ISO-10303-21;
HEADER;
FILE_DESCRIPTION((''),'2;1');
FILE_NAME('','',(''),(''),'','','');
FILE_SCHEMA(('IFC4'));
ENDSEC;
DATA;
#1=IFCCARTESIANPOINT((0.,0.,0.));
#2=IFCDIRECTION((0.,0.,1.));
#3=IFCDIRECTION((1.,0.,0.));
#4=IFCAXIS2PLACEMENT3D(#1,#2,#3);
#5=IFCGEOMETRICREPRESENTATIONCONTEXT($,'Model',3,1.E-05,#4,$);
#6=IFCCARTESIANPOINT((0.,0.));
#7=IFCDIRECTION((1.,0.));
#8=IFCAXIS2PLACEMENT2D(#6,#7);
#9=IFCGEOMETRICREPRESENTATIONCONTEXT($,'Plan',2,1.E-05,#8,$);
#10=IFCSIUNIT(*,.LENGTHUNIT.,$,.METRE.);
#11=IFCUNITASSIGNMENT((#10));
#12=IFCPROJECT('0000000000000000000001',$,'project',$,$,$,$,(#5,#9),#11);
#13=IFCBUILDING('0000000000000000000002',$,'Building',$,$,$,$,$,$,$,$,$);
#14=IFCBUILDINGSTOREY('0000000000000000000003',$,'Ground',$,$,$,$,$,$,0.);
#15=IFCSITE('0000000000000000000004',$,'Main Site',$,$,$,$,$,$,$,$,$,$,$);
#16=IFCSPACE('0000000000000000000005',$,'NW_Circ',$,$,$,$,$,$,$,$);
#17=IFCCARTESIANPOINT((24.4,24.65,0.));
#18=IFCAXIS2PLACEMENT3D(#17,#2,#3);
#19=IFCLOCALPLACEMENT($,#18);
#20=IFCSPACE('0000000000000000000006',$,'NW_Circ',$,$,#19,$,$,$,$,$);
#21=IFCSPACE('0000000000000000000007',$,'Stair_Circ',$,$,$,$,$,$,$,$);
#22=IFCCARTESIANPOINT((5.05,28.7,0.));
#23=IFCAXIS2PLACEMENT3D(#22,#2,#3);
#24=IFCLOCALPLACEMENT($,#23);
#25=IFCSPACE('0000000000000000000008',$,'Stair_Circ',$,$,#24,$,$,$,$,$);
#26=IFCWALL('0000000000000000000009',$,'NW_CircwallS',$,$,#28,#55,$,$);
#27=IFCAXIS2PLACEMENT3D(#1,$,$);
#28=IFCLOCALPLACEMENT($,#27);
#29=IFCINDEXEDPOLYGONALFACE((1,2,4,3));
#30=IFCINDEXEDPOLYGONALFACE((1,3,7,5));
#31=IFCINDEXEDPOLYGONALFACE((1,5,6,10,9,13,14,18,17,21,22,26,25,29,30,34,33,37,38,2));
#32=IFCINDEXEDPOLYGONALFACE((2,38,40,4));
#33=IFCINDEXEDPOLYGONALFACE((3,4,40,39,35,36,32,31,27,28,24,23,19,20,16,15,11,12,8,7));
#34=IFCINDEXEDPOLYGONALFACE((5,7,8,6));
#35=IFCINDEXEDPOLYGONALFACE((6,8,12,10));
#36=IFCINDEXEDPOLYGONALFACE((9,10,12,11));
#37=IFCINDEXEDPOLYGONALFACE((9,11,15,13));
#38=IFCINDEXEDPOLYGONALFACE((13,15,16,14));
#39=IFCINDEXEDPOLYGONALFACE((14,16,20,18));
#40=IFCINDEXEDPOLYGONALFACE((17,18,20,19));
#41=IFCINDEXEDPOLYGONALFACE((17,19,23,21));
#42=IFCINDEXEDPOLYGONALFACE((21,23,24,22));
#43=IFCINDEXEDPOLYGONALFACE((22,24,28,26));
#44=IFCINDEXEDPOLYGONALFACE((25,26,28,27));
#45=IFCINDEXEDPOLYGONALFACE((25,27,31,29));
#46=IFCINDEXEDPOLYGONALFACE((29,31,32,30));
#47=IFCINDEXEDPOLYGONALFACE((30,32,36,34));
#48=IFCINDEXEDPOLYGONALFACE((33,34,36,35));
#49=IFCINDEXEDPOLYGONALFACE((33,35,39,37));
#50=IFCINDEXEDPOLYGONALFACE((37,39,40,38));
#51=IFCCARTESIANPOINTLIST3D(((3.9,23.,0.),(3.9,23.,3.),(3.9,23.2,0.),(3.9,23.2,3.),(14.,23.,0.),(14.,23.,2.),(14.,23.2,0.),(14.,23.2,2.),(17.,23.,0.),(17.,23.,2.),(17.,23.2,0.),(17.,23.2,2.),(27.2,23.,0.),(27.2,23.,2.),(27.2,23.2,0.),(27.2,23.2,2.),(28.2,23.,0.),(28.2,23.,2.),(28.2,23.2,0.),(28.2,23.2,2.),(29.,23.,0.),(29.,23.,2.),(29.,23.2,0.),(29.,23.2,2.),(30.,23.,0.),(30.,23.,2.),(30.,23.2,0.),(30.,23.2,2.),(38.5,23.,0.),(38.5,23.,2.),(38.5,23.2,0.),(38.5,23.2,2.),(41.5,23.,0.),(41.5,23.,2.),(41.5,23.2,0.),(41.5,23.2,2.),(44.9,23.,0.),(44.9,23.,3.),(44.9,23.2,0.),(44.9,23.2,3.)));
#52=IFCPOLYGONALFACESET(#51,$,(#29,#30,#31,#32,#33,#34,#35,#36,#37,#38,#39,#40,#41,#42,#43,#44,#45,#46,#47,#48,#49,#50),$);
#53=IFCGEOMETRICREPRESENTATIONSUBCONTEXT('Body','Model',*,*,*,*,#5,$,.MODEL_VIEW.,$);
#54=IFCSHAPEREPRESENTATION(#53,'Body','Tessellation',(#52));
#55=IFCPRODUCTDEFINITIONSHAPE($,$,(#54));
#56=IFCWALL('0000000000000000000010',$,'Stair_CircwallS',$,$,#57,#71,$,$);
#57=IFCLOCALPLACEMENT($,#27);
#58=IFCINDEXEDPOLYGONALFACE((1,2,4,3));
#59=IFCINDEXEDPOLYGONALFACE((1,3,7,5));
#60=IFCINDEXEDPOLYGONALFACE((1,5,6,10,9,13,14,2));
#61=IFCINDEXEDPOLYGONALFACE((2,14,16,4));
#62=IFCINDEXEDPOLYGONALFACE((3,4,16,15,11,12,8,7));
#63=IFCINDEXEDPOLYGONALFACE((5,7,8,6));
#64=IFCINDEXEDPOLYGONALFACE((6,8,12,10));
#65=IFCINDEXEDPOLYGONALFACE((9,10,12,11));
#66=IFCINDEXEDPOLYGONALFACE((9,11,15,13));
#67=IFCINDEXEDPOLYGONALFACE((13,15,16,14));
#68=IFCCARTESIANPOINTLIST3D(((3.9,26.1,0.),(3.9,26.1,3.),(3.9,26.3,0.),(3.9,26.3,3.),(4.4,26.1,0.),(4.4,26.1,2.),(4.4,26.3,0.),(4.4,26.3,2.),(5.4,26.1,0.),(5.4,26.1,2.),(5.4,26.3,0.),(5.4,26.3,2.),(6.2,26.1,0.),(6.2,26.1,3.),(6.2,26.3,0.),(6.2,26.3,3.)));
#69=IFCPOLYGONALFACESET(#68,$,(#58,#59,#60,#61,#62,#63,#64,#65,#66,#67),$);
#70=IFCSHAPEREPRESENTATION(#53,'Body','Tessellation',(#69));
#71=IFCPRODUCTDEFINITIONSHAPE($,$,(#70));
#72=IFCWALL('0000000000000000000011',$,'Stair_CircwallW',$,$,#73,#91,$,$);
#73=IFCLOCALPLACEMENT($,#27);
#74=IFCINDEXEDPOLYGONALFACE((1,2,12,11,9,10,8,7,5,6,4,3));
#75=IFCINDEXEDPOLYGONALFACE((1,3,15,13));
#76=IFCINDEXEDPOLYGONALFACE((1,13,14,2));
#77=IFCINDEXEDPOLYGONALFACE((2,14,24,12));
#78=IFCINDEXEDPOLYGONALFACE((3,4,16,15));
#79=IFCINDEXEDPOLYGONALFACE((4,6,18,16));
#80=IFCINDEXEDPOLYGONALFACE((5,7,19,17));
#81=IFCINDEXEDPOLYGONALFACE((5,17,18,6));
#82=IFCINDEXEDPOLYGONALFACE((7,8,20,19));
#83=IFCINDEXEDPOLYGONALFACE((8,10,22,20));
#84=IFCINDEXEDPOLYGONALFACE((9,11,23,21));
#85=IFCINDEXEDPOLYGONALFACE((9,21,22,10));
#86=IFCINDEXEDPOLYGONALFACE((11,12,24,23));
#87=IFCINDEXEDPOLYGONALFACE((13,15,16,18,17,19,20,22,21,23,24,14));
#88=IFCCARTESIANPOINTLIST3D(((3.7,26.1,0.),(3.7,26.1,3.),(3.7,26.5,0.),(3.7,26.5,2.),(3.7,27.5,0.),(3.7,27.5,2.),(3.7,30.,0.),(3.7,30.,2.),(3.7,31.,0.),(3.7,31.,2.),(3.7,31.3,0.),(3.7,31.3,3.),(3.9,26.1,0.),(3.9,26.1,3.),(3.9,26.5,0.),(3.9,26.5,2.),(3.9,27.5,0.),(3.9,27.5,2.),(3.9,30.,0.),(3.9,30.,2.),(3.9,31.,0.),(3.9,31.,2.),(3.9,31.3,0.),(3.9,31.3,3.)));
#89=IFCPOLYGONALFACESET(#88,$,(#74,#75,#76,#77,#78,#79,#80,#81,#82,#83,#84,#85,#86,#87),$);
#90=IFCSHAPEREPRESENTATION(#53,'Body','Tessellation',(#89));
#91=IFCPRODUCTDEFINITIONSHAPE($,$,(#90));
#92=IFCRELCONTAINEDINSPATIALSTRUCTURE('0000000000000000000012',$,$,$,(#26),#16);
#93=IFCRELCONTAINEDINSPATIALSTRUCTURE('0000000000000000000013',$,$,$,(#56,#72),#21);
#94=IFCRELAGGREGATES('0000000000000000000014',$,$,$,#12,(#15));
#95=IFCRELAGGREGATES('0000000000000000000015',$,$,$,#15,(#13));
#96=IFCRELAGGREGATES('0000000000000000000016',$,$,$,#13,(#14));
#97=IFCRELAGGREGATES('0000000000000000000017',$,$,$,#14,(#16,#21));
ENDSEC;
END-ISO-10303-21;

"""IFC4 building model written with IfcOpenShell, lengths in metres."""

from ifc_helpers import new_model, si_unit, frame, origin_with_axes, origin_2d_with_axis, place, context, subcontext, project, spatial, indexed_curve, outline, extrude, element, save


model = new_model("IFC4")

# Units and contexts
model_context = context("Model", 3, precision=1e-05, world=origin_with_axes())
plan_context = context("Plan", 2, precision=1e-05, world=origin_2d_with_axis())
body_context = subcontext(model_context, "Body", "Model", "MODEL_VIEW")
ifc_project = project(units=[si_unit("LENGTHUNIT", "METRE")], contexts=[model_context, plan_context])

# Site, building, storey
site = spatial("IfcSite", under=ifc_project, Name="Main Site")
building = spatial("IfcBuilding", under=site, Name="Building")
storey = spatial("IfcBuildingStorey", under=building, Name="Ground", Elevation=0.0)

# Shared definitions
space_1 = spatial("IfcSpace", under=storey, Name="NW_Circ")

# Shared definitions
space_2_placement = place(None, frame((24.4, 24.65, 0.0), z_axis=(0.0, 0.0, 1.0), x_axis=(1.0, 0.0, 0.0)))
space_2 = spatial("IfcSpace", at=space_2_placement, Name="NW_Circ")

# Wall, openings
wall_1_placement = place(None, frame((3.9, 23.0, 0.0), z_axis=(0.0, 0.0, 1.0), x_axis=(1.0, 0.0, 0.0)))
wall_1 = element("IfcWall", 1, at=wall_1_placement, inside=space_1, Name="NW_CircwallS", context=body_context, shape_type="SweptSolid", body=[
    extrude(outline(indexed_curve([(0.0, 0.0), (0.0, 0.2), (41.0, 0.2), (41.0, 0.0), (0.0, 0.0)], self_intersect=False)), origin_with_axes(), (0.0, 0.0, 1.0), 3.0),
])
opening_1_placement = place(wall_1_placement, frame((10.1, 0.0, 0.0), z_axis=(0.0, 0.0, 1.0), x_axis=(1.0, 0.0, 0.0)))
element("IfcOpeningElement", 2, at=opening_1_placement, inside=space_2, cuts=wall_1, context=body_context, shape_type="SweptSolid", body=[
    extrude(outline(indexed_curve([(0.0, 0.0), (0.0, 0.4), (3.0, 0.4), (3.0, 0.0), (0.0, 0.0)], self_intersect=False)), origin_with_axes(), (0.0, 0.0, 1.0), 2.0),
])
opening_2_placement = place(wall_1_placement, frame((25.1, 0.0, 0.0), z_axis=(0.0, 0.0, 1.0), x_axis=(1.0, 0.0, 0.0)))
element("IfcOpeningElement", 3, at=opening_2_placement, inside=space_2, cuts=wall_1, context=body_context, shape_type="SweptSolid", body=[
    extrude(outline(indexed_curve([(0.0, 0.0), (0.0, 0.4), (1.0, 0.4), (1.0, 0.0), (0.0, 0.0)], self_intersect=False)), origin_with_axes(), (0.0, 0.0, 1.0), 2.0),
])
opening_3_placement = place(wall_1_placement, frame((23.3, 0.0, 0.0), z_axis=(0.0, 0.0, 1.0), x_axis=(1.0, 0.0, 0.0)))
element("IfcOpeningElement", 4, at=opening_3_placement, inside=space_2, cuts=wall_1, context=body_context, shape_type="SweptSolid", body=[
    extrude(outline(indexed_curve([(0.0, 0.0), (0.0, 0.4), (1.0, 0.4), (1.0, 0.0), (0.0, 0.0)], self_intersect=False)), origin_with_axes(), (0.0, 0.0, 1.0), 2.0),
])
opening_4_placement = place(wall_1_placement, frame((34.6, 0.0, 0.0), z_axis=(0.0, 0.0, 1.0), x_axis=(1.0, 0.0, 0.0)))
element("IfcOpeningElement", 5, at=opening_4_placement, inside=space_2, cuts=wall_1, context=body_context, shape_type="SweptSolid", body=[
    extrude(outline(indexed_curve([(0.0, 0.0), (0.0, 0.4), (3.0, 0.4), (3.0, 0.0), (0.0, 0.0)], self_intersect=False)), origin_with_axes(), (0.0, 0.0, 1.0), 2.0),
])

# Shared definitions
space_3 = spatial("IfcSpace", under=storey, Name="Stair_Circ")

# Wall
wall_2_placement = place(None, frame((3.9, 26.1, 0.0), z_axis=(0.0, 0.0, 1.0), x_axis=(1.0, 0.0, 0.0)))
wall_2 = element("IfcWall", 6, at=wall_2_placement, inside=space_3, Name="Stair_CircwallS", context=body_context, shape_type="SweptSolid", body=[
    extrude(outline(indexed_curve([(0.0, 0.0), (0.0, 0.2), (2.3, 0.2), (2.3, 0.0), (0.0, 0.0)], self_intersect=False)), origin_with_axes(), (0.0, 0.0, 1.0), 3.0),
])

# Shared definitions
space_4_placement = place(None, frame((5.05, 28.7, 0.0), z_axis=(0.0, 0.0, 1.0), x_axis=(1.0, 0.0, 0.0)))
space_4 = spatial("IfcSpace", at=space_4_placement, Name="Stair_Circ")

# Opening
opening_5_placement = place(wall_2_placement, frame((0.5, 0.0, 0.0), z_axis=(0.0, 0.0, 1.0), x_axis=(1.0, 0.0, 0.0)))
element("IfcOpeningElement", 7, at=opening_5_placement, inside=space_4, cuts=wall_2, context=body_context, shape_type="SweptSolid", body=[
    extrude(outline(indexed_curve([(0.0, 0.0), (0.0, 0.4), (1.0, 0.4), (1.0, 0.0), (0.0, 0.0)], self_intersect=False)), origin_with_axes(), (0.0, 0.0, 1.0), 2.0),
])

# Wall, openings
wall_3_placement = place(None, frame((3.9, 26.1, 0.0), z_axis=(0.0, 0.0, 1.0), x_axis=(0.0, 1.0, 0.0)))
wall_3 = element("IfcWall", 8, at=wall_3_placement, inside=space_3, Name="Stair_CircwallW", context=body_context, shape_type="SweptSolid", body=[
    extrude(outline(indexed_curve([(0.0, 0.0), (0.0, 0.2), (5.2, 0.2), (5.2, 0.0), (0.0, 0.0)], self_intersect=False)), origin_with_axes(), (0.0, 0.0, 1.0), 3.0),
])
opening_6_placement = place(wall_3_placement, frame((0.4, 0.0, 0.0), z_axis=(0.0, 0.0, 1.0), x_axis=(1.0, 0.0, 0.0)))
element("IfcOpeningElement", 9, at=opening_6_placement, inside=space_4, cuts=wall_3, context=body_context, shape_type="SweptSolid", body=[
    extrude(outline(indexed_curve([(0.0, 0.0), (0.0, 0.4), (1.0, 0.4), (1.0, 0.0), (0.0, 0.0)], self_intersect=False)), origin_with_axes(), (0.0, 0.0, 1.0), 2.0),
])
opening_7_placement = place(wall_3_placement, frame((3.9, 0.0, 0.0), z_axis=(0.0, 0.0, 1.0), x_axis=(1.0, 0.0, 0.0)))
element("IfcOpeningElement", 10, at=opening_7_placement, inside=space_4, cuts=wall_3, context=body_context, shape_type="SweptSolid", body=[
    extrude(outline(indexed_curve([(0.0, 0.0), (0.0, 0.4), (1.0, 0.4), (1.0, 0.0), (0.0, 0.0)], self_intersect=False)), origin_with_axes(), (0.0, 0.0, 1.0), 2.0),
])

save(model, "model.ifc")
